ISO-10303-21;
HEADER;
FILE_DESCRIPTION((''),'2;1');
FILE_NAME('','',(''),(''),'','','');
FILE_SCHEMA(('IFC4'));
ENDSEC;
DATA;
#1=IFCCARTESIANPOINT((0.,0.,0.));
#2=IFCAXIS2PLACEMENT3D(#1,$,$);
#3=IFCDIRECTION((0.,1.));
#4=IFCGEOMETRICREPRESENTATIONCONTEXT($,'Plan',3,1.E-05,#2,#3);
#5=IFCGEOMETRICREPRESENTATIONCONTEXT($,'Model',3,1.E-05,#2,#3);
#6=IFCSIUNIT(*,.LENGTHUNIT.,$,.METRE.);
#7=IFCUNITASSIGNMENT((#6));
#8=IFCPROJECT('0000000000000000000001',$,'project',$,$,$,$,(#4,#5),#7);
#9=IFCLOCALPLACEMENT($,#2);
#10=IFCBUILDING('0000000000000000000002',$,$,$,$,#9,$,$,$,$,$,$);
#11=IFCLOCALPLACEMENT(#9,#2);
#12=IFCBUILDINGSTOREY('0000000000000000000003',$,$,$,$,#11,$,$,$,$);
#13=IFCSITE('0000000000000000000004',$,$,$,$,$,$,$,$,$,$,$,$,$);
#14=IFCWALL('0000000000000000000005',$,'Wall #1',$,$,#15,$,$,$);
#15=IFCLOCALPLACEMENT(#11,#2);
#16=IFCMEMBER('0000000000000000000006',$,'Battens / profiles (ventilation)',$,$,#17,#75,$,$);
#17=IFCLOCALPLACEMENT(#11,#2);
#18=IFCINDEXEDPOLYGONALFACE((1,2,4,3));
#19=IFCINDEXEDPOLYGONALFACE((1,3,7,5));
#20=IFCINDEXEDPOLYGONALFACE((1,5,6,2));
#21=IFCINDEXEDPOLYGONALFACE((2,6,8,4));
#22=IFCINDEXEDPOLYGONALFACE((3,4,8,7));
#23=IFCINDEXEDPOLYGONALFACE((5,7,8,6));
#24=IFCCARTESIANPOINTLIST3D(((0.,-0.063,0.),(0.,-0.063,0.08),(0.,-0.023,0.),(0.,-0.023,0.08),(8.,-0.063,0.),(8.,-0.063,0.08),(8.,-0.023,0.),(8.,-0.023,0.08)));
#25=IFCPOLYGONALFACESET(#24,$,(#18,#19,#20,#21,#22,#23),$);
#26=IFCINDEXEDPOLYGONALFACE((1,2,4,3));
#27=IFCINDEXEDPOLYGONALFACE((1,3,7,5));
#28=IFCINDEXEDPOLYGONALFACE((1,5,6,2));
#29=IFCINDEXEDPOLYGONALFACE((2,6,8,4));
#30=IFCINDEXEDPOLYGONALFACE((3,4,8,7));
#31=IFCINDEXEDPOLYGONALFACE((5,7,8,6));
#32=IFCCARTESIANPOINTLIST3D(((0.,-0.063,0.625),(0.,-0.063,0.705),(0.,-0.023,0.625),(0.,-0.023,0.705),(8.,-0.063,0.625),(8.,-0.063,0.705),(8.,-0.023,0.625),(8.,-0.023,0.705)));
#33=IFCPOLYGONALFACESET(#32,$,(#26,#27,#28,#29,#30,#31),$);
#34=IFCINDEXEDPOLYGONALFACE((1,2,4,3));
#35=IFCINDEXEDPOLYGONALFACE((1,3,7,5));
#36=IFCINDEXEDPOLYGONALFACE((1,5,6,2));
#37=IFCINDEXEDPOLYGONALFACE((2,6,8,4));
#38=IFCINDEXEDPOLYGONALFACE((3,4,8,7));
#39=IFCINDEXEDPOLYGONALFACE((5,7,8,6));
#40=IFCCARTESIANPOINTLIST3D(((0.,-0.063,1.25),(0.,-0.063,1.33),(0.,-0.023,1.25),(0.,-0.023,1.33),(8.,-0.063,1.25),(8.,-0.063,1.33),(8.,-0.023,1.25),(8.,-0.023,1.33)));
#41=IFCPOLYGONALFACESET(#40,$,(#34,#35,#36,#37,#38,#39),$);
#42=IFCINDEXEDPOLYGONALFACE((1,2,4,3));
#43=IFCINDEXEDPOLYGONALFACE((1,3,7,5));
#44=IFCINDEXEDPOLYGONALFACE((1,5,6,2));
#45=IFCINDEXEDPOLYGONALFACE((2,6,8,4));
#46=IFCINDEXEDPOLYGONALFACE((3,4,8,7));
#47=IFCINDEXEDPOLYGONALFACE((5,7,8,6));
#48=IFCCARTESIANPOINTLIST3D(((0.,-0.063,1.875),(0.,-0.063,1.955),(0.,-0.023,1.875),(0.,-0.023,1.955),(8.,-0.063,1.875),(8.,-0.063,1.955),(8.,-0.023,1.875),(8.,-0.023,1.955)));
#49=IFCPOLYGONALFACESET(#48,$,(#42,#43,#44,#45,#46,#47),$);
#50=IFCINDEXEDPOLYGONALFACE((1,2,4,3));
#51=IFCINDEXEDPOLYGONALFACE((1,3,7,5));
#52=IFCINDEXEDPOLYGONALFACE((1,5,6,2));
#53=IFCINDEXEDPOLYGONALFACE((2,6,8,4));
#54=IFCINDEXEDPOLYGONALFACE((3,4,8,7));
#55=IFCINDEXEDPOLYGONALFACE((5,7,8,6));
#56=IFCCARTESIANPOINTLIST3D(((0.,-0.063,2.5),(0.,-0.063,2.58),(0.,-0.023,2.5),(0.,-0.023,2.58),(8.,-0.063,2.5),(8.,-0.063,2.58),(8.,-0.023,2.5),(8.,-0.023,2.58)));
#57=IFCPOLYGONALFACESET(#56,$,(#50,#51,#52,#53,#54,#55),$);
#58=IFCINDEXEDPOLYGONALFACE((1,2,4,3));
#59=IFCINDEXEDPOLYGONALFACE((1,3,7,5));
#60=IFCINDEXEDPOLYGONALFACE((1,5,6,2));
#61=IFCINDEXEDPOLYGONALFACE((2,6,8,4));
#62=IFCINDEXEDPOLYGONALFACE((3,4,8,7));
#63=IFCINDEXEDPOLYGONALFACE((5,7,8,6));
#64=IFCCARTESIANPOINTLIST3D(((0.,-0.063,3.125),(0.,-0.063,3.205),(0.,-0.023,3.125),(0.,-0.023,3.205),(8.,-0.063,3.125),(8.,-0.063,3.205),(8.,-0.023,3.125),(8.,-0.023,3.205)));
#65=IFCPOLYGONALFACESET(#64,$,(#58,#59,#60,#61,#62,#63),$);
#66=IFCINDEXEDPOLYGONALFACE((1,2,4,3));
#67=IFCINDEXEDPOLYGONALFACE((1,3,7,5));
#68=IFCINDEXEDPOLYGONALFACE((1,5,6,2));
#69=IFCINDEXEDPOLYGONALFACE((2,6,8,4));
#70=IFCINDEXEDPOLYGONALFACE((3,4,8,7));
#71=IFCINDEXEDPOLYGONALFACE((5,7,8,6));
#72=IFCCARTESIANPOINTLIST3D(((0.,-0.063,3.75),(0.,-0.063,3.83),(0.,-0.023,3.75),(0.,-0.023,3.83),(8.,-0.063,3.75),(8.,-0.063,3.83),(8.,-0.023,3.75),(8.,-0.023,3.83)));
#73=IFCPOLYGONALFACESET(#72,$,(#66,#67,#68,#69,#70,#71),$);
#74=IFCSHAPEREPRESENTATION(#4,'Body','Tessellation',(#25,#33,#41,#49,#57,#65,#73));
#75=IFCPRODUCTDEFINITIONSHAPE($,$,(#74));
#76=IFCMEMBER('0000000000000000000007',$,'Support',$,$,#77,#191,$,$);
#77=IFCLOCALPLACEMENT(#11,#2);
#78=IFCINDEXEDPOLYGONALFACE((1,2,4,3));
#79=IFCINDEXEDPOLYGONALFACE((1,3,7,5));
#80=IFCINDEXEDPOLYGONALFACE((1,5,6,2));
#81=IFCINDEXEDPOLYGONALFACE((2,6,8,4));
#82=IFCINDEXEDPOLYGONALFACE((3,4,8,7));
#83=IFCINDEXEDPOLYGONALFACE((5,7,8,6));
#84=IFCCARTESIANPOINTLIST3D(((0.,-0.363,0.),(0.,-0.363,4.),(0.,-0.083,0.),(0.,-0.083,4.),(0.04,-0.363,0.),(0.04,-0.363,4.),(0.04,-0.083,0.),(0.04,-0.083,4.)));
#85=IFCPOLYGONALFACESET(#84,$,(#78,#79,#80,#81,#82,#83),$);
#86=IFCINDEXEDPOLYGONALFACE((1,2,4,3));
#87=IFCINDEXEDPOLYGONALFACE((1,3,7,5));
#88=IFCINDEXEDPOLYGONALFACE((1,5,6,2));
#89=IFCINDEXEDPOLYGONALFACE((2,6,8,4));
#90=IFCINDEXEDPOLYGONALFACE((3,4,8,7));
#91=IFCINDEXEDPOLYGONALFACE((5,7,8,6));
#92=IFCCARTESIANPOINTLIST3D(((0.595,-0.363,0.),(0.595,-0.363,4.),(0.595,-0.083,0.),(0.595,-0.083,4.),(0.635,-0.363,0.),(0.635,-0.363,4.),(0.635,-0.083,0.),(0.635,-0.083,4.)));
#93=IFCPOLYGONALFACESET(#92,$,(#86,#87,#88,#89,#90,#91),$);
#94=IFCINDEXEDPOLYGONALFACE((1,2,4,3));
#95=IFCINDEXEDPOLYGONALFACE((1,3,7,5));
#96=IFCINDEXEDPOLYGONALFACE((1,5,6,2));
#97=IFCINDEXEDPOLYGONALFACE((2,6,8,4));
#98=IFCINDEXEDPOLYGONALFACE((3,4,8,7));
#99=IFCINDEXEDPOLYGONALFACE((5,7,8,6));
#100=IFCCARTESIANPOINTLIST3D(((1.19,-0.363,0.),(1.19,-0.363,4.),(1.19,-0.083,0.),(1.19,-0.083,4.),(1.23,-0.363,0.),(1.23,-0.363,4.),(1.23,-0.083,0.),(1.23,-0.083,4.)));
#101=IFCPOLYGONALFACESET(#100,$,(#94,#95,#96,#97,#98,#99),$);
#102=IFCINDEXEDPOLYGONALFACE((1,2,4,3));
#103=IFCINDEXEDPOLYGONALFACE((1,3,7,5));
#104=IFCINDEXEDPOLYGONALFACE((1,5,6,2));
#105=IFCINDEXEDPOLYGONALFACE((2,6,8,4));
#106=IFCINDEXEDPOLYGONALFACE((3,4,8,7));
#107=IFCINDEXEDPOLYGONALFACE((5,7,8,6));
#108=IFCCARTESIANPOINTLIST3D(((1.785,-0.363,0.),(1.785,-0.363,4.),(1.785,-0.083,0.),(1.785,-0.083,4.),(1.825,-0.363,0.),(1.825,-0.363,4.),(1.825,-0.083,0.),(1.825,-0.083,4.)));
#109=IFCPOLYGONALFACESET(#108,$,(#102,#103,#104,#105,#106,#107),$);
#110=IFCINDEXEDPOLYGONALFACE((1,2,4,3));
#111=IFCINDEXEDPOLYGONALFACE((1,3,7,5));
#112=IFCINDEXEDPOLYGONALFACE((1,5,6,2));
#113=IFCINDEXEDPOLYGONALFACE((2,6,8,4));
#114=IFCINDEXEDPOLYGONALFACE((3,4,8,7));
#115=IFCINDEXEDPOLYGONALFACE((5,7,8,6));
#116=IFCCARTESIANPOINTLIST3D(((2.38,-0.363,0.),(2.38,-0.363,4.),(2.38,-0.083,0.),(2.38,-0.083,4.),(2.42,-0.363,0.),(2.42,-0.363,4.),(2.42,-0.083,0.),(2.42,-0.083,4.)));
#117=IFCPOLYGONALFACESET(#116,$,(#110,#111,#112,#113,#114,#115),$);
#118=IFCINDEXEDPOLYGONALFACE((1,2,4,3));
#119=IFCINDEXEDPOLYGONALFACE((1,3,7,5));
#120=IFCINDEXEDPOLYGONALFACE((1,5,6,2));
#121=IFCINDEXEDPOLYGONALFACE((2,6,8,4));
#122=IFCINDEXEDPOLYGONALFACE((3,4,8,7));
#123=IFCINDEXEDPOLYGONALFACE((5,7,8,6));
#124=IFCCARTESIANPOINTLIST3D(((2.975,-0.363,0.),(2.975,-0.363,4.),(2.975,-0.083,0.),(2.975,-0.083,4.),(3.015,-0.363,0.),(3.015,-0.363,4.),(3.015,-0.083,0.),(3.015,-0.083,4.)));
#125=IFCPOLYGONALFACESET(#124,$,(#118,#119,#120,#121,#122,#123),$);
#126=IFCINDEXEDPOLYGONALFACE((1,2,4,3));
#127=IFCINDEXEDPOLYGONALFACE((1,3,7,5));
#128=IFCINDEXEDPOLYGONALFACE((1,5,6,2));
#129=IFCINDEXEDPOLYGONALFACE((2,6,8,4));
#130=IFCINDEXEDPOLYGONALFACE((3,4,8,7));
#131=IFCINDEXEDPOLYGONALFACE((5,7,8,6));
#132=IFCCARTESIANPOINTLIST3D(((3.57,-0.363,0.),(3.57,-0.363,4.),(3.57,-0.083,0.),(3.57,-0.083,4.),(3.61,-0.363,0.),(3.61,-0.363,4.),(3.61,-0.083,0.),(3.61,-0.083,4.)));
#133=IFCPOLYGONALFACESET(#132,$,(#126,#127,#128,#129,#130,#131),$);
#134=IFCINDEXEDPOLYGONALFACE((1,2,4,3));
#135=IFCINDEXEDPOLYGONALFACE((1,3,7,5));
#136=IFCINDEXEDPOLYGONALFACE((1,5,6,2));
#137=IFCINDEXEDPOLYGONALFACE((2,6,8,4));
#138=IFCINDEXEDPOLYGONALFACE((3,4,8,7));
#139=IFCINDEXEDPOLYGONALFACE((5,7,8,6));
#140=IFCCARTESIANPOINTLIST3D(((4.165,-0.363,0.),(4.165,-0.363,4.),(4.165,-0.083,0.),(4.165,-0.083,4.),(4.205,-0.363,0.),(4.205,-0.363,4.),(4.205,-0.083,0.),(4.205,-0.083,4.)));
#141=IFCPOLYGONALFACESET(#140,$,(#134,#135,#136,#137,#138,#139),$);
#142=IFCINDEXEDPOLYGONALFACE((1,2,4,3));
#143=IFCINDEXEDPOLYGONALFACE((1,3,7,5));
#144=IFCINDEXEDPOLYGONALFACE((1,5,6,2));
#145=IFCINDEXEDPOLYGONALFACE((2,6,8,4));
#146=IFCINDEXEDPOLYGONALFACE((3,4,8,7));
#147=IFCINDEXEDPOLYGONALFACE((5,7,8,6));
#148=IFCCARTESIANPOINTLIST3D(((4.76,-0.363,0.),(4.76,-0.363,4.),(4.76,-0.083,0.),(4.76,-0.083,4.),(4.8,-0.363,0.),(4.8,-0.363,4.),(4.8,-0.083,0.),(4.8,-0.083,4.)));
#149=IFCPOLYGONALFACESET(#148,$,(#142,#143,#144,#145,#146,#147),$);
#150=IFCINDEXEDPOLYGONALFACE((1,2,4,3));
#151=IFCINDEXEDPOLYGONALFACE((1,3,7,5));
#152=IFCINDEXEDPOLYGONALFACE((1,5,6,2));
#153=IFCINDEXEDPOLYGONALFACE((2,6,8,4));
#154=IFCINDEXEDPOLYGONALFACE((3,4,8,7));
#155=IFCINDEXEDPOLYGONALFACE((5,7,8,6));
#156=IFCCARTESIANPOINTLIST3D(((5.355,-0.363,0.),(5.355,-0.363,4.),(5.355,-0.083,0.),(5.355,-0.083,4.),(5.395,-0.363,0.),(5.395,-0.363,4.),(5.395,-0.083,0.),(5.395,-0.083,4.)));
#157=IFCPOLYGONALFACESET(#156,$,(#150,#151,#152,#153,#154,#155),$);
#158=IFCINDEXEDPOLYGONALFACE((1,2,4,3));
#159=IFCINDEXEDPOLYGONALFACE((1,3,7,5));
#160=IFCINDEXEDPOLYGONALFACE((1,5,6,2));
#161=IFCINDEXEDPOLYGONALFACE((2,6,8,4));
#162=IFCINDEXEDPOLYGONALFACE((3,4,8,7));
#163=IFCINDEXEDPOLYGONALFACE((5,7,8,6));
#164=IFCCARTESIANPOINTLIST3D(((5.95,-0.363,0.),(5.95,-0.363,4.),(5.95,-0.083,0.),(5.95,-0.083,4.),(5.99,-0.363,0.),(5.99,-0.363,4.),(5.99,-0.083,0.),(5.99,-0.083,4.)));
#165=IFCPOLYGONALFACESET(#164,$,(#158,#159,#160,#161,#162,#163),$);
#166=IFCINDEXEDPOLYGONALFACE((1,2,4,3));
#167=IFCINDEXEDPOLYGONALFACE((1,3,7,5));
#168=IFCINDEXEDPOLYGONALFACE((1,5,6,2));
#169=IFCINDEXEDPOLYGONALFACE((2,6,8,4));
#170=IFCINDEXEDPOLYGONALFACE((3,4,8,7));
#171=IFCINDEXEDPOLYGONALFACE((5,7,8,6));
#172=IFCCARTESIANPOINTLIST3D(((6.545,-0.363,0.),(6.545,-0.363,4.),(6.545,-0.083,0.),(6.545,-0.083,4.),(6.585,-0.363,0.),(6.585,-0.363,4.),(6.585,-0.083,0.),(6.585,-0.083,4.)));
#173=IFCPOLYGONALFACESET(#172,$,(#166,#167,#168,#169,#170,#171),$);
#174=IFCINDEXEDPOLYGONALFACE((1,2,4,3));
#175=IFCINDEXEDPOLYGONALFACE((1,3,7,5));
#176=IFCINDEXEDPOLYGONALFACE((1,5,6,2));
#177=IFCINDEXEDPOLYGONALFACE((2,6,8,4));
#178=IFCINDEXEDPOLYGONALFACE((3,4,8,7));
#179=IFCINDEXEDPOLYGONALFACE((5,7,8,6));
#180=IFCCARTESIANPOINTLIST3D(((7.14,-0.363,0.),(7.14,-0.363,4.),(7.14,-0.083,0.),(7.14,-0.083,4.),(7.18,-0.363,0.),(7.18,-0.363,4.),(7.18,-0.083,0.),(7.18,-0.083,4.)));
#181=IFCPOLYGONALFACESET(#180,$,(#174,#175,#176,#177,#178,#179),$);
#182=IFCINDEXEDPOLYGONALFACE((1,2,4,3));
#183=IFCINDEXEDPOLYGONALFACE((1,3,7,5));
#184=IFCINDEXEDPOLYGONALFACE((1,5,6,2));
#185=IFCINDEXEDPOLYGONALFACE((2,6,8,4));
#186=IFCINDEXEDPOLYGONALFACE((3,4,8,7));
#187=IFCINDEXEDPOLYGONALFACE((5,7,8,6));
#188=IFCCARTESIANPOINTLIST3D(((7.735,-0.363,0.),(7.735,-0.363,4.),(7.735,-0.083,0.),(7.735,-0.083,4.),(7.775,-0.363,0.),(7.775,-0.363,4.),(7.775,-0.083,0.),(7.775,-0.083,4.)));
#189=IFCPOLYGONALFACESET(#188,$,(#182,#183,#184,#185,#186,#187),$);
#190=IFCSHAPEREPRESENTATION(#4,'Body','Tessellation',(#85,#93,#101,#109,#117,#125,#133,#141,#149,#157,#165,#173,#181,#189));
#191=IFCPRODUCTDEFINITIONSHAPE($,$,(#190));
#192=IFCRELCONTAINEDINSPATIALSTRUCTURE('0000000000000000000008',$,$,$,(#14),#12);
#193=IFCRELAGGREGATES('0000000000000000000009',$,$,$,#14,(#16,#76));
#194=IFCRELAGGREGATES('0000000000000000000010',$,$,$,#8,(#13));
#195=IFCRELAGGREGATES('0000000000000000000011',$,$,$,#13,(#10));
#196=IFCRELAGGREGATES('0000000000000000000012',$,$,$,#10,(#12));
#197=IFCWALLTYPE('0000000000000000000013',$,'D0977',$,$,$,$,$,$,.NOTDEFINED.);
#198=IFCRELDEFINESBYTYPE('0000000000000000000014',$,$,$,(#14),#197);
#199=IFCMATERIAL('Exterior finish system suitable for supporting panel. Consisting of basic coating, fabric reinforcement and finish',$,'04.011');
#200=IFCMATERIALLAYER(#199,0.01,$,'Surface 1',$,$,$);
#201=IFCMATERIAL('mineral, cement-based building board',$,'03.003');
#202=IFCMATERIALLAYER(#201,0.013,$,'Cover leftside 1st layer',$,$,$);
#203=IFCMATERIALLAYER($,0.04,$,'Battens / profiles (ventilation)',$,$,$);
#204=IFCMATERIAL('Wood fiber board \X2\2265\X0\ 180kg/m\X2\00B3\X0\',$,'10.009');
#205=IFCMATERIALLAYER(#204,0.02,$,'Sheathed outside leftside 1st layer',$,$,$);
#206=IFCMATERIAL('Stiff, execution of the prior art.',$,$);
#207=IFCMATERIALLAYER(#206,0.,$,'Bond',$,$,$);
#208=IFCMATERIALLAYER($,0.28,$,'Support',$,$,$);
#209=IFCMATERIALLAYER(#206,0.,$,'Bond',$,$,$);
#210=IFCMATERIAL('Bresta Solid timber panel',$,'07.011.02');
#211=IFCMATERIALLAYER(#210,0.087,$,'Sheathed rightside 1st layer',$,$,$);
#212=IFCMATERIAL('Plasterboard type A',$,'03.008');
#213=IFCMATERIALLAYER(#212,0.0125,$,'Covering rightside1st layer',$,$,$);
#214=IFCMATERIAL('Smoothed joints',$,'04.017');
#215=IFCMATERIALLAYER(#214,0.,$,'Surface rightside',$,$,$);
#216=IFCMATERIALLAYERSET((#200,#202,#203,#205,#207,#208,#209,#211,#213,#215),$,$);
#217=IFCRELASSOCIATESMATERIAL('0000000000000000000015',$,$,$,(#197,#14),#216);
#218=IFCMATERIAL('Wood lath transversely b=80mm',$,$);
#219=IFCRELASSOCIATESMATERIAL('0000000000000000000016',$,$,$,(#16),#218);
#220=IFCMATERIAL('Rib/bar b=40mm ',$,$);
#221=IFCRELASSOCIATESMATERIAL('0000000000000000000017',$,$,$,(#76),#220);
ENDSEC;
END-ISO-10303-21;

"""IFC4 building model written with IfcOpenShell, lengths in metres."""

from ifc_helpers import new_model, si_unit, direction, frame, frame_2d, origin, place, context, project, spatial, rectangle, extrude, material, layer, layer_set, type_object, element, aggregate, save


model = new_model("IFC4")

# Units and contexts
plan_context = context("Plan", 3, precision=1e-05, world=origin(), true_north=direction((0.0, 1.0)))
model_context = context("Model", 3, precision=1e-05, world=origin(), true_north=direction((0.0, 1.0)))
ifc_project = project(units=[si_unit("LENGTHUNIT", "METRE")], contexts=[plan_context, model_context])

# Site, building, storey
site = spatial("IfcSite", under=ifc_project)
building_placement = place(None, origin())
building = spatial("IfcBuilding", under=site, at=building_placement)
storey_placement = place(building_placement, origin())
storey = spatial("IfcBuildingStorey", under=building, at=storey_placement)

# Wall, members
ifc_material_1 = material(Name="Exterior finish system suitable for supporting panel. Consisting of basic coating, fabric reinforcement and finish", Category="04.011")
ifc_layer_1 = layer(ifc_material_1, 0.01, Name="Surface 1")
ifc_material_2 = material(Name="mineral, cement-based building board", Category="03.003")
ifc_layer_2 = layer(ifc_material_2, 0.013, Name="Cover leftside 1st layer")
ifc_layer_3 = layer(None, 0.04, Name="Battens / profiles (ventilation)")
ifc_material_3 = material(Name="Wood fiber board ≥ 180kg/m³", Category="10.009")
ifc_layer_4 = layer(ifc_material_3, 0.02, Name="Sheathed outside leftside 1st layer")
ifc_material_4 = material(Name="Stiff, execution of the prior art.")
ifc_layer_5 = layer(ifc_material_4, 0.0, Name="Bond")
ifc_layer_6 = layer(None, 0.28, Name="Support")
ifc_layer_7 = layer(ifc_material_4, 0.0, Name="Bond")
ifc_material_5 = material(Name="Bresta Solid timber panel", Category="07.011.02")
ifc_layer_8 = layer(ifc_material_5, 0.087, Name="Sheathed rightside 1st layer")
ifc_material_6 = material(Name="Plasterboard type A", Category="03.008")
ifc_layer_9 = layer(ifc_material_6, 0.0125, Name="Covering rightside1st layer")
ifc_material_7 = material(Name="Smoothed joints", Category="04.017")
ifc_layer_10 = layer(ifc_material_7, 0.0, Name="Surface rightside")
ifc_layer_set = layer_set([ifc_layer_1, ifc_layer_2, ifc_layer_3, ifc_layer_4, ifc_layer_5, ifc_layer_6, ifc_layer_7, ifc_layer_8, ifc_layer_9, ifc_layer_10])
wall_type = type_object("IfcWallType", Name="D0977", PredefinedType="NOTDEFINED", material=ifc_layer_set)
wall_placement = place(None, frame((0.0, 0.0, 0.0), z_axis=(0.0, -1.0, 0.0), x_axis=(1.0, 0.0, 0.0)))
wall = element("IfcWall", 1, at=wall_placement, inside=storey, type_object=wall_type, material=ifc_layer_set, Name="Wall #1")
ifc_material_8 = material(Name="Wood lath transversely b=80mm")
member_1_placement = place(wall_placement, origin())
member_1 = element("IfcMember", 2, at=member_1_placement, material=ifc_material_8, Name="Battens / profiles (ventilation)", context=plan_context, shape_type="SweptSolid", body=[
    extrude(rectangle(XDim=0.08, YDim=0.04, at=frame_2d((0.04, 0.02), x_axis=(1.0, 0.0))), frame((0.0, 0.0, 0.023), z_axis=(1.0, 0.0, 0.0), x_axis=(0.0, 1.0, 0.0)), (0.0, 0.0, 1.0), 8.0),
    extrude(rectangle(XDim=0.08, YDim=0.04, at=frame_2d((0.04, 0.02), x_axis=(1.0, 0.0))), frame((0.0, 0.625, 0.023), z_axis=(1.0, 0.0, 0.0), x_axis=(0.0, 1.0, 0.0)), (0.0, 0.0, 1.0), 8.0),
    extrude(rectangle(XDim=0.08, YDim=0.04, at=frame_2d((0.04, 0.02), x_axis=(1.0, 0.0))), frame((0.0, 1.25, 0.023), z_axis=(1.0, 0.0, 0.0), x_axis=(0.0, 1.0, 0.0)), (0.0, 0.0, 1.0), 8.0),
    extrude(rectangle(XDim=0.08, YDim=0.04, at=frame_2d((0.04, 0.02), x_axis=(1.0, 0.0))), frame((0.0, 1.875, 0.023), z_axis=(1.0, 0.0, 0.0), x_axis=(0.0, 1.0, 0.0)), (0.0, 0.0, 1.0), 8.0),
    extrude(rectangle(XDim=0.08, YDim=0.04, at=frame_2d((0.04, 0.02), x_axis=(1.0, 0.0))), frame((0.0, 2.5, 0.023), z_axis=(1.0, 0.0, 0.0), x_axis=(0.0, 1.0, 0.0)), (0.0, 0.0, 1.0), 8.0),
    extrude(rectangle(XDim=0.08, YDim=0.04, at=frame_2d((0.04, 0.02), x_axis=(1.0, 0.0))), frame((0.0, 3.125, 0.023), z_axis=(1.0, 0.0, 0.0), x_axis=(0.0, 1.0, 0.0)), (0.0, 0.0, 1.0), 8.0),
    extrude(rectangle(XDim=0.08, YDim=0.04, at=frame_2d((0.04, 0.02), x_axis=(1.0, 0.0))), frame((0.0, 3.75, 0.023), z_axis=(1.0, 0.0, 0.0), x_axis=(0.0, 1.0, 0.0)), (0.0, 0.0, 1.0), 8.0),
])
ifc_material_9 = material(Name="Rib/bar b=40mm ")
member_2_placement = place(wall_placement, origin())
member_2 = element("IfcMember", 3, at=member_2_placement, material=ifc_material_9, Name="Support", context=plan_context, shape_type="SweptSolid", body=[
    extrude(rectangle(XDim=0.04, YDim=0.28, at=frame_2d((0.02, 0.14), x_axis=(1.0, 0.0))), frame((0.0, 4.0, 0.083), z_axis=(0.0, -1.0, 0.0), x_axis=(1.0, 0.0, 0.0)), (0.0, 0.0, 1.0), 4.0),
    extrude(rectangle(XDim=0.04, YDim=0.28, at=frame_2d((0.02, 0.14), x_axis=(1.0, 0.0))), frame((0.595, 4.0, 0.083), z_axis=(0.0, -1.0, 0.0), x_axis=(1.0, 0.0, 0.0)), (0.0, 0.0, 1.0), 4.0),
    extrude(rectangle(XDim=0.04, YDim=0.28, at=frame_2d((0.02, 0.14), x_axis=(1.0, 0.0))), frame((1.19, 4.0, 0.083), z_axis=(0.0, -1.0, 0.0), x_axis=(1.0, 0.0, 0.0)), (0.0, 0.0, 1.0), 4.0),
    extrude(rectangle(XDim=0.04, YDim=0.28, at=frame_2d((0.02, 0.14), x_axis=(1.0, 0.0))), frame((1.785, 4.0, 0.083), z_axis=(0.0, -1.0, 0.0), x_axis=(1.0, 0.0, 0.0)), (0.0, 0.0, 1.0), 4.0),
    extrude(rectangle(XDim=0.04, YDim=0.28, at=frame_2d((0.02, 0.14), x_axis=(1.0, 0.0))), frame((2.38, 4.0, 0.083), z_axis=(0.0, -1.0, 0.0), x_axis=(1.0, 0.0, 0.0)), (0.0, 0.0, 1.0), 4.0),
    extrude(rectangle(XDim=0.04, YDim=0.28, at=frame_2d((0.02, 0.14), x_axis=(1.0, 0.0))), frame((2.975, 4.0, 0.083), z_axis=(0.0, -1.0, 0.0), x_axis=(1.0, 0.0, 0.0)), (0.0, 0.0, 1.0), 4.0),
    extrude(rectangle(XDim=0.04, YDim=0.28, at=frame_2d((0.02, 0.14), x_axis=(1.0, 0.0))), frame((3.57, 4.0, 0.083), z_axis=(0.0, -1.0, 0.0), x_axis=(1.0, 0.0, 0.0)), (0.0, 0.0, 1.0), 4.0),
    extrude(rectangle(XDim=0.04, YDim=0.28, at=frame_2d((0.02, 0.14), x_axis=(1.0, 0.0))), frame((4.165, 4.0, 0.083), z_axis=(0.0, -1.0, 0.0), x_axis=(1.0, 0.0, 0.0)), (0.0, 0.0, 1.0), 4.0),
    extrude(rectangle(XDim=0.04, YDim=0.28, at=frame_2d((0.02, 0.14), x_axis=(1.0, 0.0))), frame((4.76, 4.0, 0.083), z_axis=(0.0, -1.0, 0.0), x_axis=(1.0, 0.0, 0.0)), (0.0, 0.0, 1.0), 4.0),
    extrude(rectangle(XDim=0.04, YDim=0.28, at=frame_2d((0.02, 0.14), x_axis=(1.0, 0.0))), frame((5.355, 4.0, 0.083), z_axis=(0.0, -1.0, 0.0), x_axis=(1.0, 0.0, 0.0)), (0.0, 0.0, 1.0), 4.0),
    extrude(rectangle(XDim=0.04, YDim=0.28, at=frame_2d((0.02, 0.14), x_axis=(1.0, 0.0))), frame((5.95, 4.0, 0.083), z_axis=(0.0, -1.0, 0.0), x_axis=(1.0, 0.0, 0.0)), (0.0, 0.0, 1.0), 4.0),
    extrude(rectangle(XDim=0.04, YDim=0.28, at=frame_2d((0.02, 0.14), x_axis=(1.0, 0.0))), frame((6.545, 4.0, 0.083), z_axis=(0.0, -1.0, 0.0), x_axis=(1.0, 0.0, 0.0)), (0.0, 0.0, 1.0), 4.0),
    extrude(rectangle(XDim=0.04, YDim=0.28, at=frame_2d((0.02, 0.14), x_axis=(1.0, 0.0))), frame((7.14, 4.0, 0.083), z_axis=(0.0, -1.0, 0.0), x_axis=(1.0, 0.0, 0.0)), (0.0, 0.0, 1.0), 4.0),
    extrude(rectangle(XDim=0.04, YDim=0.28, at=frame_2d((0.02, 0.14), x_axis=(1.0, 0.0))), frame((7.735, 4.0, 0.083), z_axis=(0.0, -1.0, 0.0), x_axis=(1.0, 0.0, 0.0)), (0.0, 0.0, 1.0), 4.0),
])
aggregate(wall, [member_1, member_2])

save(model, "model.ifc")
